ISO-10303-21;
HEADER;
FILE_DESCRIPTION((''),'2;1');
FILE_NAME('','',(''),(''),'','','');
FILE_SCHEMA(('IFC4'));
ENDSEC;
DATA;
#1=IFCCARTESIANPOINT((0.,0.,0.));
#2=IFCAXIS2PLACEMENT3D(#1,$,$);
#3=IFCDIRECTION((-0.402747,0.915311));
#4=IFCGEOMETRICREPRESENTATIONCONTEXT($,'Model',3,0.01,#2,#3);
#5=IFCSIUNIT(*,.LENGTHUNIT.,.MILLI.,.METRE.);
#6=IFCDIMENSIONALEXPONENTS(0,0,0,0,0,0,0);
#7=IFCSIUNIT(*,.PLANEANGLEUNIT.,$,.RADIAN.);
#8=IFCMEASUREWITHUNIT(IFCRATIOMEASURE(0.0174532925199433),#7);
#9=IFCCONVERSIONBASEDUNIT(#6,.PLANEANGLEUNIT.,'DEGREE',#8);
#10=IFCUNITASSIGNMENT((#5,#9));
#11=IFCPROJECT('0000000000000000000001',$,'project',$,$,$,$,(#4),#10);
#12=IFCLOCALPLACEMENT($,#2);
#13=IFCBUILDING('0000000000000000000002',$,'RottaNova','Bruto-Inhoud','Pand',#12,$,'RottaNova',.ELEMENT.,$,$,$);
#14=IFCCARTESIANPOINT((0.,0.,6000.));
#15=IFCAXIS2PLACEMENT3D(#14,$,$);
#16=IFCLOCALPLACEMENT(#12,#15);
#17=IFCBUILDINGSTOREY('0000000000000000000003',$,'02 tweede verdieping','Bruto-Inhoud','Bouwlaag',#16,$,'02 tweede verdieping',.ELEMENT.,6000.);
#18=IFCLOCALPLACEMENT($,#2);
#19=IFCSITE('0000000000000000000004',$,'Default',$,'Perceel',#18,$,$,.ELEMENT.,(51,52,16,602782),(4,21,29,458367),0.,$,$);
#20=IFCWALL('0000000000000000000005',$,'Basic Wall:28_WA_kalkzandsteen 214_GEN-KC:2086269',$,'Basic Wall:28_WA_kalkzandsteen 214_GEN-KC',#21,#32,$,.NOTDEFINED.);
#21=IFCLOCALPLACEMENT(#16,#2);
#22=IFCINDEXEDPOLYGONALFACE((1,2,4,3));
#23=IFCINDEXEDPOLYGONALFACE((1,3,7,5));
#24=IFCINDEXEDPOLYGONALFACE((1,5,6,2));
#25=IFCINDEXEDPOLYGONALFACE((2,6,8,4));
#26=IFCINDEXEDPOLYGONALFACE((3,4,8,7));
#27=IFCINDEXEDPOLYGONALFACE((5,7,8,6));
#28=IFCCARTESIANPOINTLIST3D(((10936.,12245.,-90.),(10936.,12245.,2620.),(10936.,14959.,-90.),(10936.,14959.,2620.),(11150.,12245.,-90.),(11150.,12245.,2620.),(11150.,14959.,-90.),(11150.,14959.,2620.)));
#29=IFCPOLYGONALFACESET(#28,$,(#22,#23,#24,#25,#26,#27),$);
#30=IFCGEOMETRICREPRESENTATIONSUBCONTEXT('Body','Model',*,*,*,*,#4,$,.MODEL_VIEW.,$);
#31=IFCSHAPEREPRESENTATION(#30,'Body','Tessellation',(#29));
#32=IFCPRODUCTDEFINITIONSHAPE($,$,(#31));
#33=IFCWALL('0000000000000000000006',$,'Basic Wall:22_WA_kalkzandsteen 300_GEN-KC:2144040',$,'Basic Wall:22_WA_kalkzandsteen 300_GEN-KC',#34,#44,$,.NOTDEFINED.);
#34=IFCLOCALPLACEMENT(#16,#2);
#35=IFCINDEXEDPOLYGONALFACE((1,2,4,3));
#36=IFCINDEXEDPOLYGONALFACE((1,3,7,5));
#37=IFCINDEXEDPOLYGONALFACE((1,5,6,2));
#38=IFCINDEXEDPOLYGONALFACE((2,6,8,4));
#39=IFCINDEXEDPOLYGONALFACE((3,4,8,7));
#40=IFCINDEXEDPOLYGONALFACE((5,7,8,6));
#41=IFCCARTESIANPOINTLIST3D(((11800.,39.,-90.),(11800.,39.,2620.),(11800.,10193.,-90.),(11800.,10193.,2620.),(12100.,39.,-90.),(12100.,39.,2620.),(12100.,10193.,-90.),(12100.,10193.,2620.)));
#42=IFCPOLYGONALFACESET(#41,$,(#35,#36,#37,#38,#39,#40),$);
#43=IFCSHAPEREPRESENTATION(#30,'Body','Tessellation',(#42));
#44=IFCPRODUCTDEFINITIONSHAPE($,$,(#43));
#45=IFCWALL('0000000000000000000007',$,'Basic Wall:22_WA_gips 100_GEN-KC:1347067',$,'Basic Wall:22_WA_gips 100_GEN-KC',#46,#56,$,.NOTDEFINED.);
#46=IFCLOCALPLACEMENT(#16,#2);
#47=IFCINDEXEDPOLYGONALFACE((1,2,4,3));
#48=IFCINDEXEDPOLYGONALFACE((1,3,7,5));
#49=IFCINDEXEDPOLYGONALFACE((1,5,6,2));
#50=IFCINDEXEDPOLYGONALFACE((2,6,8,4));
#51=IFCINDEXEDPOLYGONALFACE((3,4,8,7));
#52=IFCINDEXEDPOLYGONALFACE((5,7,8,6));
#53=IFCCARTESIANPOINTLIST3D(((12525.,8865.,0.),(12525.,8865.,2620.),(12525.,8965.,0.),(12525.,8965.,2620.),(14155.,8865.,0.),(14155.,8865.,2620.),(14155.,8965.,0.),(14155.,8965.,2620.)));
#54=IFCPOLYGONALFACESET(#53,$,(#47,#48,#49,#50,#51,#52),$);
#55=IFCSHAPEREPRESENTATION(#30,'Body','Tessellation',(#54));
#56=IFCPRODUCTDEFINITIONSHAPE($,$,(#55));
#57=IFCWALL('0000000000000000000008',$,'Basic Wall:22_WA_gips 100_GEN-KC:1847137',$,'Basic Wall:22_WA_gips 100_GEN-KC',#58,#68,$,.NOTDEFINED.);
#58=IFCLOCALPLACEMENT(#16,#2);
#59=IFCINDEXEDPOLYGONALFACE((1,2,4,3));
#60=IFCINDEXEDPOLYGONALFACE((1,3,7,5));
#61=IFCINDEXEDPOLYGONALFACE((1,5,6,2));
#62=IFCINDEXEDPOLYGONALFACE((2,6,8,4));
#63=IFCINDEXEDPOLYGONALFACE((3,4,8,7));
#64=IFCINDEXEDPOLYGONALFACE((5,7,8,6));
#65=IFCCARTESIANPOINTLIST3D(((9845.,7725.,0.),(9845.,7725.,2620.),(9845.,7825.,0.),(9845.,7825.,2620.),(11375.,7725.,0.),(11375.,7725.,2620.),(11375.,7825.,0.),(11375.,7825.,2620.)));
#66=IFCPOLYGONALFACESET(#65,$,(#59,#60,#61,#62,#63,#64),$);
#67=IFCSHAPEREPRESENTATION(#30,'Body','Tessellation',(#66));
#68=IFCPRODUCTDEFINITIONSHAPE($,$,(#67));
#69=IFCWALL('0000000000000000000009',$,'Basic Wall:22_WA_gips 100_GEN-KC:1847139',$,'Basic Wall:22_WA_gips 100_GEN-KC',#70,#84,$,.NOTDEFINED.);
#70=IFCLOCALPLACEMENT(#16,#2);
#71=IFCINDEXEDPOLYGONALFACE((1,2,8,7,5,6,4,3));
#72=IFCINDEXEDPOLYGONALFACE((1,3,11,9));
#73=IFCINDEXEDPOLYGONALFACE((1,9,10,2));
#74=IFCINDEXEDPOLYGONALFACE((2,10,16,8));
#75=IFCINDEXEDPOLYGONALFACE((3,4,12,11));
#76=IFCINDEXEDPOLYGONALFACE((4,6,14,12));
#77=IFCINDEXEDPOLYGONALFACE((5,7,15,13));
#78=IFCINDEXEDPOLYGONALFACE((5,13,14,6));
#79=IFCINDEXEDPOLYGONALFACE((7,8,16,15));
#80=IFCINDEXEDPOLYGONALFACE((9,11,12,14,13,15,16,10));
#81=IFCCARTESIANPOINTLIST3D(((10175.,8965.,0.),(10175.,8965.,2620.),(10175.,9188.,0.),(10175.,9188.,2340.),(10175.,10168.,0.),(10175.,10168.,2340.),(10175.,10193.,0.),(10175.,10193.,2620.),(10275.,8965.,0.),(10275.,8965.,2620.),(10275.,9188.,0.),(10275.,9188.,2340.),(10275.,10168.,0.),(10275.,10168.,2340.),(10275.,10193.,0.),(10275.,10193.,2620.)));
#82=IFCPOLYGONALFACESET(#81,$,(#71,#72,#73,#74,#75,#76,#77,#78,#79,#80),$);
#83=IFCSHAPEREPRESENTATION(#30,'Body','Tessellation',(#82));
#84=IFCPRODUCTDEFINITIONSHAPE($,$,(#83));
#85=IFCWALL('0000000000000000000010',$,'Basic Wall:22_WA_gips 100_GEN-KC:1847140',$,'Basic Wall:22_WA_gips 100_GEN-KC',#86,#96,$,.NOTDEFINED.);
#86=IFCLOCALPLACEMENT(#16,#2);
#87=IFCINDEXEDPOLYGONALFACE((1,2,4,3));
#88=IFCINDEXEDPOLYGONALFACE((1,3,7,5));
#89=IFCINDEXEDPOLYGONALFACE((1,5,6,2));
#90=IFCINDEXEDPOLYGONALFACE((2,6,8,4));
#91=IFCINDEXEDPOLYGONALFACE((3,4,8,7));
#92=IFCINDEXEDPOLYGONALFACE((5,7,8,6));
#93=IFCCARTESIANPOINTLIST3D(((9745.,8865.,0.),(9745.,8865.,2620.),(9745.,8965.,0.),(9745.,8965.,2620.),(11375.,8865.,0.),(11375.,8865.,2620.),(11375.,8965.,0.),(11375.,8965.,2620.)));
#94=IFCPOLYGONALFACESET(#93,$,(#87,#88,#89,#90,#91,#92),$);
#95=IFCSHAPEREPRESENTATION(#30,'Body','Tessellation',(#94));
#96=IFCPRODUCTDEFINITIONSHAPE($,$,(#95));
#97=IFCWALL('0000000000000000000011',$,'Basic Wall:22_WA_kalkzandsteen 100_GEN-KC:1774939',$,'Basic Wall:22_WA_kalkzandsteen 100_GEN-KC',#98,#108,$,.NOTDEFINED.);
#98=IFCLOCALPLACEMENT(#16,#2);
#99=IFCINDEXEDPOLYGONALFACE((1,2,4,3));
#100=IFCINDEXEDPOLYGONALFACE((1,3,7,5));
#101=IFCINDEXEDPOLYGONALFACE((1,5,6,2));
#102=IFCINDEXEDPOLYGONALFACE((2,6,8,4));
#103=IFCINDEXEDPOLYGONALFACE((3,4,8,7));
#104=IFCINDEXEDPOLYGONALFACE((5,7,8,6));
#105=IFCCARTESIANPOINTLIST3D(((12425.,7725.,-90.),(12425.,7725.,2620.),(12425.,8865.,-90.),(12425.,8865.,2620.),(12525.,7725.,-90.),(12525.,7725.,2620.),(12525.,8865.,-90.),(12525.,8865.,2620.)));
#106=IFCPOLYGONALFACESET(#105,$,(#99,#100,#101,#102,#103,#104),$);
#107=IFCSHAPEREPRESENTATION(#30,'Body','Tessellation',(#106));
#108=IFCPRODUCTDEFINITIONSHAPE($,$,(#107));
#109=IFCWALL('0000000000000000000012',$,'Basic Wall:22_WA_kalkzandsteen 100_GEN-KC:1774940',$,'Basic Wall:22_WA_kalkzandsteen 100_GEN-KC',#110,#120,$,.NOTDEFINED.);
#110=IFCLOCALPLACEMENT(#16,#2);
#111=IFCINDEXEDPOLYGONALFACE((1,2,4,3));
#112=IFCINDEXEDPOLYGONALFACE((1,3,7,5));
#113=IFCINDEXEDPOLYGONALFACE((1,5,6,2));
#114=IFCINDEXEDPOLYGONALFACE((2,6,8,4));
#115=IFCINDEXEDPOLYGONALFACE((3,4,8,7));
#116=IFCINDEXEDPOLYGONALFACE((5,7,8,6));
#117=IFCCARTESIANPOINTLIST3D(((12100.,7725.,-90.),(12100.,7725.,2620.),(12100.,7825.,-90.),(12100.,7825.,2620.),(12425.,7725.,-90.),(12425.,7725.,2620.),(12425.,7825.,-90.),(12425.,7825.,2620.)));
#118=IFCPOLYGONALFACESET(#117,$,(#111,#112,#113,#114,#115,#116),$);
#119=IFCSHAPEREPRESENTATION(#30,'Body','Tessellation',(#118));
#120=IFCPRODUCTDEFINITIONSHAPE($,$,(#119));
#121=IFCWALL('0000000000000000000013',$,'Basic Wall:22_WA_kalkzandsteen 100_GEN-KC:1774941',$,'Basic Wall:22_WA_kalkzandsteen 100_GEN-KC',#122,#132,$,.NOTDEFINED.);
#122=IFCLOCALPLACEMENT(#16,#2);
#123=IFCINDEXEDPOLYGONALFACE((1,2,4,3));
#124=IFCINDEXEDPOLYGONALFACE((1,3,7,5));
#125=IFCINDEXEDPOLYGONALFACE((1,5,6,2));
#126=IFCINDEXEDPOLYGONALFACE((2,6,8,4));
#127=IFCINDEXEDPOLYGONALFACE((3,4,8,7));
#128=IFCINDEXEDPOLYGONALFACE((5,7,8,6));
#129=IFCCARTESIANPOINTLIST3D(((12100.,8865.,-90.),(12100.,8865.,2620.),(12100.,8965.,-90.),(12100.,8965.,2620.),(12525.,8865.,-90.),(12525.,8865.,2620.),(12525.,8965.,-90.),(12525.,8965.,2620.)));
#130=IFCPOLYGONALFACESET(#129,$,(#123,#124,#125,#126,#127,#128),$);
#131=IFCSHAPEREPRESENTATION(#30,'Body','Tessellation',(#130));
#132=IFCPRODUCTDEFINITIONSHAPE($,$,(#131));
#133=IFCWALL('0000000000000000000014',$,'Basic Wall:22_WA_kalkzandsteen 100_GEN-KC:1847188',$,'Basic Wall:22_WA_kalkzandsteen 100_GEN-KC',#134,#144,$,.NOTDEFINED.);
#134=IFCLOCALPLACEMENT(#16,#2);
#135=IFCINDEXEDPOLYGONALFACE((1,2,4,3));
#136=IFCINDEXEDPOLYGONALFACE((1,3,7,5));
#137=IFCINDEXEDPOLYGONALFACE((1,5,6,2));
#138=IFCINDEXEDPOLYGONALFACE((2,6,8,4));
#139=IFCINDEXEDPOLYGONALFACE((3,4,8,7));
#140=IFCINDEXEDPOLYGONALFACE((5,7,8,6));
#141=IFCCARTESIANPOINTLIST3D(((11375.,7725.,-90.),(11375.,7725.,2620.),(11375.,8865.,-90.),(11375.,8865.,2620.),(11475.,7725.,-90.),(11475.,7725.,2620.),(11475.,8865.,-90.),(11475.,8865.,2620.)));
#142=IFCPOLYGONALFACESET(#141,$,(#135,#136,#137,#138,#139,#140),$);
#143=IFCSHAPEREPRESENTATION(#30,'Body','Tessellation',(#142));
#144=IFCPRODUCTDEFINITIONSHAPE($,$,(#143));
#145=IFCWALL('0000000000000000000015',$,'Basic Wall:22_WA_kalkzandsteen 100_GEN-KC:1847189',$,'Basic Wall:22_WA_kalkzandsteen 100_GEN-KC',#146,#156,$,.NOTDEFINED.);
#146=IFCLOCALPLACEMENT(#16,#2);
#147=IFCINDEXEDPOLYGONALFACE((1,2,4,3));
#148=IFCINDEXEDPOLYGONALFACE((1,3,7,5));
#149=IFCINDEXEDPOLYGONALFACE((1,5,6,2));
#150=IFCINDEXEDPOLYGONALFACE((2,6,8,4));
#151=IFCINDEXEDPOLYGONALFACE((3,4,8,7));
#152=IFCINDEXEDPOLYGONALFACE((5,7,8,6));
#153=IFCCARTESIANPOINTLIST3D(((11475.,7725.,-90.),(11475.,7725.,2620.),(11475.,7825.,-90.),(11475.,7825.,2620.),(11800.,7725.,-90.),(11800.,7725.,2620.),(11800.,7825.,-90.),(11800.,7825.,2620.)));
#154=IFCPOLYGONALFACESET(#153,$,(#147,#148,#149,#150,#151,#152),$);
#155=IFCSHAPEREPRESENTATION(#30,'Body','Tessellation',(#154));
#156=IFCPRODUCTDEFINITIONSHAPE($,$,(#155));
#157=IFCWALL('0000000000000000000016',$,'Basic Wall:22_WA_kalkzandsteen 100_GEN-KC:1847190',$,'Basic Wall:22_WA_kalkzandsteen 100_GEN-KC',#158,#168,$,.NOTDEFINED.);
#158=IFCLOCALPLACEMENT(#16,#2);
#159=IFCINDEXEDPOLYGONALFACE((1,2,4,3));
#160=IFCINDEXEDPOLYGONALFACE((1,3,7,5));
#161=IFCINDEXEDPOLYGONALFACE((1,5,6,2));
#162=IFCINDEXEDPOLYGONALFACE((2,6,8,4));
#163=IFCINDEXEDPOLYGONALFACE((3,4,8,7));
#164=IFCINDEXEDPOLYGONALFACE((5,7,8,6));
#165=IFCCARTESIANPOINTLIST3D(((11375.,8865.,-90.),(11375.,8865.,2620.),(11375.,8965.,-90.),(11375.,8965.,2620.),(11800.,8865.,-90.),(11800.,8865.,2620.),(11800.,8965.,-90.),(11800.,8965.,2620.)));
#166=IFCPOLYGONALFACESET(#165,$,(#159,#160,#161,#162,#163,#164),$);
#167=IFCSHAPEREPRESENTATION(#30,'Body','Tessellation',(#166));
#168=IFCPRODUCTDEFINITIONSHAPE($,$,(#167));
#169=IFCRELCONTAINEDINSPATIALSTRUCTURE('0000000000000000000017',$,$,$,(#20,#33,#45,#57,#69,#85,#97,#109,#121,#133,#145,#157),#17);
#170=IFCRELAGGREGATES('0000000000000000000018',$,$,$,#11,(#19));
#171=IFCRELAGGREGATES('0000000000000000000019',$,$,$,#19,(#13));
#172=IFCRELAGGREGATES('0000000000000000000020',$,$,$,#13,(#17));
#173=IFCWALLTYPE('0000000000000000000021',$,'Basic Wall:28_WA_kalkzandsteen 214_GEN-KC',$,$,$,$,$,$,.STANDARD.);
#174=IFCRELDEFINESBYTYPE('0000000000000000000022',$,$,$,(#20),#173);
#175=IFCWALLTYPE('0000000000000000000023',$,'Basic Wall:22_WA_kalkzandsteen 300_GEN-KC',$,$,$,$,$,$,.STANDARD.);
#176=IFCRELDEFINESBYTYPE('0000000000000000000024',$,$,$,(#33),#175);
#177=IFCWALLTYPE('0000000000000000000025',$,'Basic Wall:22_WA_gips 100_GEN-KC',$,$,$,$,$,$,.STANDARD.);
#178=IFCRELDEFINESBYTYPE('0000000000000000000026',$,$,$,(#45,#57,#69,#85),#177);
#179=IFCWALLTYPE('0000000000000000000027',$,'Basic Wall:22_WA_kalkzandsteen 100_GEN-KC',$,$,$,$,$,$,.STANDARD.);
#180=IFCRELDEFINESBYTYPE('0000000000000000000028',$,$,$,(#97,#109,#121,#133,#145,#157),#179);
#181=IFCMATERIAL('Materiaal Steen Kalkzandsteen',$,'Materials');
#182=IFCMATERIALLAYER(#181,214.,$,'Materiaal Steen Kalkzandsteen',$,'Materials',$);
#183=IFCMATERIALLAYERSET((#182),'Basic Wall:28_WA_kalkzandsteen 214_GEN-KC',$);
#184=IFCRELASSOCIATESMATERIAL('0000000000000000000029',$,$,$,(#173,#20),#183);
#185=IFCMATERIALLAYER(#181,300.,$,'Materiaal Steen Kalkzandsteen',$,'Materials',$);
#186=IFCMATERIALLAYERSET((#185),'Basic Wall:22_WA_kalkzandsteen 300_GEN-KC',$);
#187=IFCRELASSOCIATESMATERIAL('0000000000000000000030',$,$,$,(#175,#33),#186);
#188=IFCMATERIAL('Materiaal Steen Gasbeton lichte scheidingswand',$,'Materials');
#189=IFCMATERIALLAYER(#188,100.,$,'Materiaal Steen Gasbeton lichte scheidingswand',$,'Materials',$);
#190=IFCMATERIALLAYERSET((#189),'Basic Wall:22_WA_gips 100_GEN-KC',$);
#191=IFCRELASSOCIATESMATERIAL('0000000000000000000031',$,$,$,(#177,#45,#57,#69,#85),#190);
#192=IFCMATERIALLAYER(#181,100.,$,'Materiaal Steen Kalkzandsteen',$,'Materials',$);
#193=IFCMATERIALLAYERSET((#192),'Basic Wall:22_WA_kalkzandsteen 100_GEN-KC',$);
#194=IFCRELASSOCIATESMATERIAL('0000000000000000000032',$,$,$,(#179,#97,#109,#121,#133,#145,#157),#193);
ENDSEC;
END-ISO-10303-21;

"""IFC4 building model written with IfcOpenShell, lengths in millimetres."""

from ifc_helpers import new_model, entity, si_unit, converted_unit, direction, frame, frame_2d, origin, place, context, subcontext, project, spatial, rectangle, extrude, material, layer, layer_set, type_object, element, save


model = new_model("IFC4")

# Units and contexts
model_context = context("Model", 3, precision=0.01, world=origin(), true_north=direction((-0.402747, 0.915311)))
body_context = subcontext(model_context, "Body", "Model", "MODEL_VIEW")
ifc_project = project(units=[si_unit("LENGTHUNIT", "METRE", prefix="MILLI"), converted_unit("PLANEANGLEUNIT", "DEGREE", entity("IfcRatioMeasure", 0.0174532925199433), si_unit("PLANEANGLEUNIT", "RADIAN"), dimensions=[0, 0, 0, 0, 0, 0, 0])], contexts=[model_context])

# Site, building, storey
site_placement = place(None, origin())
site = spatial("IfcSite", under=ifc_project, at=site_placement, Name="Default", ObjectType="Perceel", CompositionType="ELEMENT", RefLatitude=(51, 52, 16, 602782), RefLongitude=(4, 21, 29, 458367), RefElevation=0.0)
building_placement = place(None, origin())
building = spatial("IfcBuilding", under=site, at=building_placement, Name="RottaNova", Description="Bruto-Inhoud", ObjectType="Pand", LongName="RottaNova", CompositionType="ELEMENT")
storey_placement = place(building_placement, frame((0.0, 0.0, 6000.0)))
storey = spatial("IfcBuildingStorey", under=building, at=storey_placement, Name="02 tweede verdieping", Description="Bruto-Inhoud", ObjectType="Bouwlaag", LongName="02 tweede verdieping", CompositionType="ELEMENT", Elevation=6000.0)

# Walls
ifc_material_1 = material(Name="Materiaal Steen Kalkzandsteen", Category="Materials")
ifc_layer_1 = layer(ifc_material_1, 214.0, Name="Materiaal Steen Kalkzandsteen", Category="Materials")
ifc_layer_set_1 = layer_set([ifc_layer_1], Name="Basic Wall:28_WA_kalkzandsteen 214_GEN-KC")
wall_type_1 = type_object("IfcWallType", Name="Basic Wall:28_WA_kalkzandsteen 214_GEN-KC", PredefinedType="STANDARD", material=ifc_layer_set_1)
wall_1_placement = place(storey_placement, frame((11043.0, 12245.0, -90.0), z_axis=(0.0, 0.0, 1.0), x_axis=(0.0, 1.0, 0.0)))
element("IfcWall", 1, at=wall_1_placement, inside=storey, type_object=wall_type_1, material=ifc_layer_set_1, Name="Basic Wall:28_WA_kalkzandsteen 214_GEN-KC:2086269", ObjectType="Basic Wall:28_WA_kalkzandsteen 214_GEN-KC", PredefinedType="NOTDEFINED", context=body_context, shape_type="SweptSolid", body=[
    extrude(rectangle(XDim=2714.0, YDim=214.0, at=frame_2d((1357.0, 0.0), x_axis=(-1.0, 0.0))), origin(), (0.0, 0.0, 1.0), 2710.0),
])
ifc_layer_2 = layer(ifc_material_1, 300.0, Name="Materiaal Steen Kalkzandsteen", Category="Materials")
ifc_layer_set_2 = layer_set([ifc_layer_2], Name="Basic Wall:22_WA_kalkzandsteen 300_GEN-KC")
wall_type_2 = type_object("IfcWallType", Name="Basic Wall:22_WA_kalkzandsteen 300_GEN-KC", PredefinedType="STANDARD", material=ifc_layer_set_2)
wall_2_placement = place(storey_placement, frame((11950.0, 39.0, -90.0), z_axis=(0.0, 0.0, 1.0), x_axis=(0.0, 1.0, 0.0)))
element("IfcWall", 2, at=wall_2_placement, inside=storey, type_object=wall_type_2, material=ifc_layer_set_2, Name="Basic Wall:22_WA_kalkzandsteen 300_GEN-KC:2144040", ObjectType="Basic Wall:22_WA_kalkzandsteen 300_GEN-KC", PredefinedType="NOTDEFINED", context=body_context, shape_type="SweptSolid", body=[
    extrude(rectangle(XDim=10154.0, YDim=300.0, at=frame_2d((5077.0, 0.0), x_axis=(-1.0, 0.0))), origin(), (0.0, 0.0, 1.0), 2710.0),
])
ifc_material_2 = material(Name="Materiaal Steen Gasbeton lichte scheidingswand", Category="Materials")
ifc_layer_3 = layer(ifc_material_2, 100.0, Name="Materiaal Steen Gasbeton lichte scheidingswand", Category="Materials")
ifc_layer_set_3 = layer_set([ifc_layer_3], Name="Basic Wall:22_WA_gips 100_GEN-KC")
wall_type_3 = type_object("IfcWallType", Name="Basic Wall:22_WA_gips 100_GEN-KC", PredefinedType="STANDARD", material=ifc_layer_set_3)
wall_3_placement = place(storey_placement, frame((12525.0, 8915.0, 0.0)))
element("IfcWall", 3, at=wall_3_placement, inside=storey, type_object=wall_type_3, material=ifc_layer_set_3, Name="Basic Wall:22_WA_gips 100_GEN-KC:1347067", ObjectType="Basic Wall:22_WA_gips 100_GEN-KC", PredefinedType="NOTDEFINED", context=body_context, shape_type="SweptSolid", body=[
    extrude(rectangle(XDim=1630.0, YDim=100.0, at=frame_2d((815.0, 0.0), x_axis=(-1.0, 0.0))), origin(), (0.0, 0.0, 1.0), 2620.0),
])
wall_4_placement = place(storey_placement, frame((9845.0, 7775.0, 0.0)))
element("IfcWall", 4, at=wall_4_placement, inside=storey, type_object=wall_type_3, material=ifc_layer_set_3, Name="Basic Wall:22_WA_gips 100_GEN-KC:1847137", ObjectType="Basic Wall:22_WA_gips 100_GEN-KC", PredefinedType="NOTDEFINED", context=body_context, shape_type="SweptSolid", body=[
    extrude(rectangle(XDim=1530.0, YDim=100.0, at=frame_2d((765.0, 0.0), x_axis=(-1.0, 0.0))), origin(), (0.0, 0.0, 1.0), 2620.0),
])

# Wall, opening
wall_5_placement = place(storey_placement, frame((10225.0, 8965.0, 0.0), z_axis=(0.0, 0.0, 1.0), x_axis=(0.0, 1.0, 0.0)))
wall_5 = element("IfcWall", 5, at=wall_5_placement, inside=storey, type_object=wall_type_3, material=ifc_layer_set_3, Name="Basic Wall:22_WA_gips 100_GEN-KC:1847139", ObjectType="Basic Wall:22_WA_gips 100_GEN-KC", PredefinedType="NOTDEFINED", context=body_context, shape_type="SweptSolid", body=[
    extrude(rectangle(XDim=1228.0, YDim=100.0, at=frame_2d((614.0, 0.0), x_axis=(1.0, 0.0))), origin(), (0.0, 0.0, 1.0), 2620.0),
])
opening_1_placement = place(wall_5_placement, frame((223.0, -50.0, -90.0)))
element("IfcOpeningElement", 6, at=opening_1_placement, cuts=wall_5, PredefinedType="OPENING", context=body_context, shape_type="SweptSolid", body=[
    extrude(rectangle(XDim=2430.0, YDim=980.0, at=frame_2d((1215.0, 490.0), x_axis=(1.0, 0.0))), frame((0.0, 0.0, 0.0), z_axis=(0.0, 1.0, 0.0), x_axis=(0.0, 0.0, 1.0)), (0.0, 0.0, 1.0), 100.0),
])

# Walls
wall_6_placement = place(storey_placement, frame((11375.0, 8915.0, 0.0), z_axis=(0.0, 0.0, 1.0), x_axis=(-1.0, 0.0, 0.0)))
element("IfcWall", 7, at=wall_6_placement, inside=storey, type_object=wall_type_3, material=ifc_layer_set_3, Name="Basic Wall:22_WA_gips 100_GEN-KC:1847140", ObjectType="Basic Wall:22_WA_gips 100_GEN-KC", PredefinedType="NOTDEFINED", context=body_context, shape_type="SweptSolid", body=[
    extrude(rectangle(XDim=1630.0, YDim=100.0, at=frame_2d((815.0, 0.0), x_axis=(-1.0, 0.0))), origin(), (0.0, 0.0, 1.0), 2620.0),
])
ifc_layer_4 = layer(ifc_material_1, 100.0, Name="Materiaal Steen Kalkzandsteen", Category="Materials")
ifc_layer_set_4 = layer_set([ifc_layer_4], Name="Basic Wall:22_WA_kalkzandsteen 100_GEN-KC")
wall_type_4 = type_object("IfcWallType", Name="Basic Wall:22_WA_kalkzandsteen 100_GEN-KC", PredefinedType="STANDARD", material=ifc_layer_set_4)
wall_7_placement = place(storey_placement, frame((12475.0, 8865.0, -90.0), z_axis=(0.0, 0.0, 1.0), x_axis=(0.0, -1.0, 0.0)))
element("IfcWall", 8, at=wall_7_placement, inside=storey, type_object=wall_type_4, material=ifc_layer_set_4, Name="Basic Wall:22_WA_kalkzandsteen 100_GEN-KC:1774939", ObjectType="Basic Wall:22_WA_kalkzandsteen 100_GEN-KC", PredefinedType="NOTDEFINED", context=body_context, shape_type="SweptSolid", body=[
    extrude(rectangle(XDim=1140.0, YDim=100.0, at=frame_2d((570.0, 0.0), x_axis=(-1.0, 0.0))), origin(), (0.0, 0.0, 1.0), 2710.0),
])
wall_8_placement = place(storey_placement, frame((12100.0, 7775.0, -90.0)))
element("IfcWall", 9, at=wall_8_placement, inside=storey, type_object=wall_type_4, material=ifc_layer_set_4, Name="Basic Wall:22_WA_kalkzandsteen 100_GEN-KC:1774940", ObjectType="Basic Wall:22_WA_kalkzandsteen 100_GEN-KC", PredefinedType="NOTDEFINED", context=body_context, shape_type="SweptSolid", body=[
    extrude(rectangle(XDim=325.0, YDim=100.0, at=frame_2d((162.5, 0.0), x_axis=(-1.0, 0.0))), origin(), (0.0, 0.0, 1.0), 2710.0),
])
wall_9_placement = place(storey_placement, frame((12100.0, 8915.0, -90.0)))
element("IfcWall", 10, at=wall_9_placement, inside=storey, type_object=wall_type_4, material=ifc_layer_set_4, Name="Basic Wall:22_WA_kalkzandsteen 100_GEN-KC:1774941", ObjectType="Basic Wall:22_WA_kalkzandsteen 100_GEN-KC", PredefinedType="NOTDEFINED", context=body_context, shape_type="SweptSolid", body=[
    extrude(rectangle(XDim=425.0, YDim=100.0, at=frame_2d((212.5, 0.0), x_axis=(-1.0, 0.0))), origin(), (0.0, 0.0, 1.0), 2710.0),
])
wall_10_placement = place(storey_placement, frame((11425.0, 8865.0, -90.0), z_axis=(0.0, 0.0, 1.0), x_axis=(0.0, -1.0, 0.0)))
element("IfcWall", 11, at=wall_10_placement, inside=storey, type_object=wall_type_4, material=ifc_layer_set_4, Name="Basic Wall:22_WA_kalkzandsteen 100_GEN-KC:1847188", ObjectType="Basic Wall:22_WA_kalkzandsteen 100_GEN-KC", PredefinedType="NOTDEFINED", context=body_context, shape_type="SweptSolid", body=[
    extrude(rectangle(XDim=1140.0, YDim=100.0, at=frame_2d((570.0, 0.0), x_axis=(-1.0, 0.0))), origin(), (0.0, 0.0, 1.0), 2710.0),
])
wall_11_placement = place(storey_placement, frame((11800.0, 7775.0, -90.0), z_axis=(0.0, 0.0, 1.0), x_axis=(-1.0, 0.0, 0.0)))
element("IfcWall", 12, at=wall_11_placement, inside=storey, type_object=wall_type_4, material=ifc_layer_set_4, Name="Basic Wall:22_WA_kalkzandsteen 100_GEN-KC:1847189", ObjectType="Basic Wall:22_WA_kalkzandsteen 100_GEN-KC", PredefinedType="NOTDEFINED", context=body_context, shape_type="SweptSolid", body=[
    extrude(rectangle(XDim=325.0, YDim=100.0, at=frame_2d((162.5, 0.0), x_axis=(-1.0, 0.0))), origin(), (0.0, 0.0, 1.0), 2710.0),
])
wall_12_placement = place(storey_placement, frame((11800.0, 8915.0, -90.0), z_axis=(0.0, 0.0, 1.0), x_axis=(-1.0, 0.0, 0.0)))
element("IfcWall", 13, at=wall_12_placement, inside=storey, type_object=wall_type_4, material=ifc_layer_set_4, Name="Basic Wall:22_WA_kalkzandsteen 100_GEN-KC:1847190", ObjectType="Basic Wall:22_WA_kalkzandsteen 100_GEN-KC", PredefinedType="NOTDEFINED", context=body_context, shape_type="SweptSolid", body=[
    extrude(rectangle(XDim=425.0, YDim=100.0, at=frame_2d((212.5, 0.0), x_axis=(-1.0, 0.0))), origin(), (0.0, 0.0, 1.0), 2710.0),
])

save(model, "model.ifc")
